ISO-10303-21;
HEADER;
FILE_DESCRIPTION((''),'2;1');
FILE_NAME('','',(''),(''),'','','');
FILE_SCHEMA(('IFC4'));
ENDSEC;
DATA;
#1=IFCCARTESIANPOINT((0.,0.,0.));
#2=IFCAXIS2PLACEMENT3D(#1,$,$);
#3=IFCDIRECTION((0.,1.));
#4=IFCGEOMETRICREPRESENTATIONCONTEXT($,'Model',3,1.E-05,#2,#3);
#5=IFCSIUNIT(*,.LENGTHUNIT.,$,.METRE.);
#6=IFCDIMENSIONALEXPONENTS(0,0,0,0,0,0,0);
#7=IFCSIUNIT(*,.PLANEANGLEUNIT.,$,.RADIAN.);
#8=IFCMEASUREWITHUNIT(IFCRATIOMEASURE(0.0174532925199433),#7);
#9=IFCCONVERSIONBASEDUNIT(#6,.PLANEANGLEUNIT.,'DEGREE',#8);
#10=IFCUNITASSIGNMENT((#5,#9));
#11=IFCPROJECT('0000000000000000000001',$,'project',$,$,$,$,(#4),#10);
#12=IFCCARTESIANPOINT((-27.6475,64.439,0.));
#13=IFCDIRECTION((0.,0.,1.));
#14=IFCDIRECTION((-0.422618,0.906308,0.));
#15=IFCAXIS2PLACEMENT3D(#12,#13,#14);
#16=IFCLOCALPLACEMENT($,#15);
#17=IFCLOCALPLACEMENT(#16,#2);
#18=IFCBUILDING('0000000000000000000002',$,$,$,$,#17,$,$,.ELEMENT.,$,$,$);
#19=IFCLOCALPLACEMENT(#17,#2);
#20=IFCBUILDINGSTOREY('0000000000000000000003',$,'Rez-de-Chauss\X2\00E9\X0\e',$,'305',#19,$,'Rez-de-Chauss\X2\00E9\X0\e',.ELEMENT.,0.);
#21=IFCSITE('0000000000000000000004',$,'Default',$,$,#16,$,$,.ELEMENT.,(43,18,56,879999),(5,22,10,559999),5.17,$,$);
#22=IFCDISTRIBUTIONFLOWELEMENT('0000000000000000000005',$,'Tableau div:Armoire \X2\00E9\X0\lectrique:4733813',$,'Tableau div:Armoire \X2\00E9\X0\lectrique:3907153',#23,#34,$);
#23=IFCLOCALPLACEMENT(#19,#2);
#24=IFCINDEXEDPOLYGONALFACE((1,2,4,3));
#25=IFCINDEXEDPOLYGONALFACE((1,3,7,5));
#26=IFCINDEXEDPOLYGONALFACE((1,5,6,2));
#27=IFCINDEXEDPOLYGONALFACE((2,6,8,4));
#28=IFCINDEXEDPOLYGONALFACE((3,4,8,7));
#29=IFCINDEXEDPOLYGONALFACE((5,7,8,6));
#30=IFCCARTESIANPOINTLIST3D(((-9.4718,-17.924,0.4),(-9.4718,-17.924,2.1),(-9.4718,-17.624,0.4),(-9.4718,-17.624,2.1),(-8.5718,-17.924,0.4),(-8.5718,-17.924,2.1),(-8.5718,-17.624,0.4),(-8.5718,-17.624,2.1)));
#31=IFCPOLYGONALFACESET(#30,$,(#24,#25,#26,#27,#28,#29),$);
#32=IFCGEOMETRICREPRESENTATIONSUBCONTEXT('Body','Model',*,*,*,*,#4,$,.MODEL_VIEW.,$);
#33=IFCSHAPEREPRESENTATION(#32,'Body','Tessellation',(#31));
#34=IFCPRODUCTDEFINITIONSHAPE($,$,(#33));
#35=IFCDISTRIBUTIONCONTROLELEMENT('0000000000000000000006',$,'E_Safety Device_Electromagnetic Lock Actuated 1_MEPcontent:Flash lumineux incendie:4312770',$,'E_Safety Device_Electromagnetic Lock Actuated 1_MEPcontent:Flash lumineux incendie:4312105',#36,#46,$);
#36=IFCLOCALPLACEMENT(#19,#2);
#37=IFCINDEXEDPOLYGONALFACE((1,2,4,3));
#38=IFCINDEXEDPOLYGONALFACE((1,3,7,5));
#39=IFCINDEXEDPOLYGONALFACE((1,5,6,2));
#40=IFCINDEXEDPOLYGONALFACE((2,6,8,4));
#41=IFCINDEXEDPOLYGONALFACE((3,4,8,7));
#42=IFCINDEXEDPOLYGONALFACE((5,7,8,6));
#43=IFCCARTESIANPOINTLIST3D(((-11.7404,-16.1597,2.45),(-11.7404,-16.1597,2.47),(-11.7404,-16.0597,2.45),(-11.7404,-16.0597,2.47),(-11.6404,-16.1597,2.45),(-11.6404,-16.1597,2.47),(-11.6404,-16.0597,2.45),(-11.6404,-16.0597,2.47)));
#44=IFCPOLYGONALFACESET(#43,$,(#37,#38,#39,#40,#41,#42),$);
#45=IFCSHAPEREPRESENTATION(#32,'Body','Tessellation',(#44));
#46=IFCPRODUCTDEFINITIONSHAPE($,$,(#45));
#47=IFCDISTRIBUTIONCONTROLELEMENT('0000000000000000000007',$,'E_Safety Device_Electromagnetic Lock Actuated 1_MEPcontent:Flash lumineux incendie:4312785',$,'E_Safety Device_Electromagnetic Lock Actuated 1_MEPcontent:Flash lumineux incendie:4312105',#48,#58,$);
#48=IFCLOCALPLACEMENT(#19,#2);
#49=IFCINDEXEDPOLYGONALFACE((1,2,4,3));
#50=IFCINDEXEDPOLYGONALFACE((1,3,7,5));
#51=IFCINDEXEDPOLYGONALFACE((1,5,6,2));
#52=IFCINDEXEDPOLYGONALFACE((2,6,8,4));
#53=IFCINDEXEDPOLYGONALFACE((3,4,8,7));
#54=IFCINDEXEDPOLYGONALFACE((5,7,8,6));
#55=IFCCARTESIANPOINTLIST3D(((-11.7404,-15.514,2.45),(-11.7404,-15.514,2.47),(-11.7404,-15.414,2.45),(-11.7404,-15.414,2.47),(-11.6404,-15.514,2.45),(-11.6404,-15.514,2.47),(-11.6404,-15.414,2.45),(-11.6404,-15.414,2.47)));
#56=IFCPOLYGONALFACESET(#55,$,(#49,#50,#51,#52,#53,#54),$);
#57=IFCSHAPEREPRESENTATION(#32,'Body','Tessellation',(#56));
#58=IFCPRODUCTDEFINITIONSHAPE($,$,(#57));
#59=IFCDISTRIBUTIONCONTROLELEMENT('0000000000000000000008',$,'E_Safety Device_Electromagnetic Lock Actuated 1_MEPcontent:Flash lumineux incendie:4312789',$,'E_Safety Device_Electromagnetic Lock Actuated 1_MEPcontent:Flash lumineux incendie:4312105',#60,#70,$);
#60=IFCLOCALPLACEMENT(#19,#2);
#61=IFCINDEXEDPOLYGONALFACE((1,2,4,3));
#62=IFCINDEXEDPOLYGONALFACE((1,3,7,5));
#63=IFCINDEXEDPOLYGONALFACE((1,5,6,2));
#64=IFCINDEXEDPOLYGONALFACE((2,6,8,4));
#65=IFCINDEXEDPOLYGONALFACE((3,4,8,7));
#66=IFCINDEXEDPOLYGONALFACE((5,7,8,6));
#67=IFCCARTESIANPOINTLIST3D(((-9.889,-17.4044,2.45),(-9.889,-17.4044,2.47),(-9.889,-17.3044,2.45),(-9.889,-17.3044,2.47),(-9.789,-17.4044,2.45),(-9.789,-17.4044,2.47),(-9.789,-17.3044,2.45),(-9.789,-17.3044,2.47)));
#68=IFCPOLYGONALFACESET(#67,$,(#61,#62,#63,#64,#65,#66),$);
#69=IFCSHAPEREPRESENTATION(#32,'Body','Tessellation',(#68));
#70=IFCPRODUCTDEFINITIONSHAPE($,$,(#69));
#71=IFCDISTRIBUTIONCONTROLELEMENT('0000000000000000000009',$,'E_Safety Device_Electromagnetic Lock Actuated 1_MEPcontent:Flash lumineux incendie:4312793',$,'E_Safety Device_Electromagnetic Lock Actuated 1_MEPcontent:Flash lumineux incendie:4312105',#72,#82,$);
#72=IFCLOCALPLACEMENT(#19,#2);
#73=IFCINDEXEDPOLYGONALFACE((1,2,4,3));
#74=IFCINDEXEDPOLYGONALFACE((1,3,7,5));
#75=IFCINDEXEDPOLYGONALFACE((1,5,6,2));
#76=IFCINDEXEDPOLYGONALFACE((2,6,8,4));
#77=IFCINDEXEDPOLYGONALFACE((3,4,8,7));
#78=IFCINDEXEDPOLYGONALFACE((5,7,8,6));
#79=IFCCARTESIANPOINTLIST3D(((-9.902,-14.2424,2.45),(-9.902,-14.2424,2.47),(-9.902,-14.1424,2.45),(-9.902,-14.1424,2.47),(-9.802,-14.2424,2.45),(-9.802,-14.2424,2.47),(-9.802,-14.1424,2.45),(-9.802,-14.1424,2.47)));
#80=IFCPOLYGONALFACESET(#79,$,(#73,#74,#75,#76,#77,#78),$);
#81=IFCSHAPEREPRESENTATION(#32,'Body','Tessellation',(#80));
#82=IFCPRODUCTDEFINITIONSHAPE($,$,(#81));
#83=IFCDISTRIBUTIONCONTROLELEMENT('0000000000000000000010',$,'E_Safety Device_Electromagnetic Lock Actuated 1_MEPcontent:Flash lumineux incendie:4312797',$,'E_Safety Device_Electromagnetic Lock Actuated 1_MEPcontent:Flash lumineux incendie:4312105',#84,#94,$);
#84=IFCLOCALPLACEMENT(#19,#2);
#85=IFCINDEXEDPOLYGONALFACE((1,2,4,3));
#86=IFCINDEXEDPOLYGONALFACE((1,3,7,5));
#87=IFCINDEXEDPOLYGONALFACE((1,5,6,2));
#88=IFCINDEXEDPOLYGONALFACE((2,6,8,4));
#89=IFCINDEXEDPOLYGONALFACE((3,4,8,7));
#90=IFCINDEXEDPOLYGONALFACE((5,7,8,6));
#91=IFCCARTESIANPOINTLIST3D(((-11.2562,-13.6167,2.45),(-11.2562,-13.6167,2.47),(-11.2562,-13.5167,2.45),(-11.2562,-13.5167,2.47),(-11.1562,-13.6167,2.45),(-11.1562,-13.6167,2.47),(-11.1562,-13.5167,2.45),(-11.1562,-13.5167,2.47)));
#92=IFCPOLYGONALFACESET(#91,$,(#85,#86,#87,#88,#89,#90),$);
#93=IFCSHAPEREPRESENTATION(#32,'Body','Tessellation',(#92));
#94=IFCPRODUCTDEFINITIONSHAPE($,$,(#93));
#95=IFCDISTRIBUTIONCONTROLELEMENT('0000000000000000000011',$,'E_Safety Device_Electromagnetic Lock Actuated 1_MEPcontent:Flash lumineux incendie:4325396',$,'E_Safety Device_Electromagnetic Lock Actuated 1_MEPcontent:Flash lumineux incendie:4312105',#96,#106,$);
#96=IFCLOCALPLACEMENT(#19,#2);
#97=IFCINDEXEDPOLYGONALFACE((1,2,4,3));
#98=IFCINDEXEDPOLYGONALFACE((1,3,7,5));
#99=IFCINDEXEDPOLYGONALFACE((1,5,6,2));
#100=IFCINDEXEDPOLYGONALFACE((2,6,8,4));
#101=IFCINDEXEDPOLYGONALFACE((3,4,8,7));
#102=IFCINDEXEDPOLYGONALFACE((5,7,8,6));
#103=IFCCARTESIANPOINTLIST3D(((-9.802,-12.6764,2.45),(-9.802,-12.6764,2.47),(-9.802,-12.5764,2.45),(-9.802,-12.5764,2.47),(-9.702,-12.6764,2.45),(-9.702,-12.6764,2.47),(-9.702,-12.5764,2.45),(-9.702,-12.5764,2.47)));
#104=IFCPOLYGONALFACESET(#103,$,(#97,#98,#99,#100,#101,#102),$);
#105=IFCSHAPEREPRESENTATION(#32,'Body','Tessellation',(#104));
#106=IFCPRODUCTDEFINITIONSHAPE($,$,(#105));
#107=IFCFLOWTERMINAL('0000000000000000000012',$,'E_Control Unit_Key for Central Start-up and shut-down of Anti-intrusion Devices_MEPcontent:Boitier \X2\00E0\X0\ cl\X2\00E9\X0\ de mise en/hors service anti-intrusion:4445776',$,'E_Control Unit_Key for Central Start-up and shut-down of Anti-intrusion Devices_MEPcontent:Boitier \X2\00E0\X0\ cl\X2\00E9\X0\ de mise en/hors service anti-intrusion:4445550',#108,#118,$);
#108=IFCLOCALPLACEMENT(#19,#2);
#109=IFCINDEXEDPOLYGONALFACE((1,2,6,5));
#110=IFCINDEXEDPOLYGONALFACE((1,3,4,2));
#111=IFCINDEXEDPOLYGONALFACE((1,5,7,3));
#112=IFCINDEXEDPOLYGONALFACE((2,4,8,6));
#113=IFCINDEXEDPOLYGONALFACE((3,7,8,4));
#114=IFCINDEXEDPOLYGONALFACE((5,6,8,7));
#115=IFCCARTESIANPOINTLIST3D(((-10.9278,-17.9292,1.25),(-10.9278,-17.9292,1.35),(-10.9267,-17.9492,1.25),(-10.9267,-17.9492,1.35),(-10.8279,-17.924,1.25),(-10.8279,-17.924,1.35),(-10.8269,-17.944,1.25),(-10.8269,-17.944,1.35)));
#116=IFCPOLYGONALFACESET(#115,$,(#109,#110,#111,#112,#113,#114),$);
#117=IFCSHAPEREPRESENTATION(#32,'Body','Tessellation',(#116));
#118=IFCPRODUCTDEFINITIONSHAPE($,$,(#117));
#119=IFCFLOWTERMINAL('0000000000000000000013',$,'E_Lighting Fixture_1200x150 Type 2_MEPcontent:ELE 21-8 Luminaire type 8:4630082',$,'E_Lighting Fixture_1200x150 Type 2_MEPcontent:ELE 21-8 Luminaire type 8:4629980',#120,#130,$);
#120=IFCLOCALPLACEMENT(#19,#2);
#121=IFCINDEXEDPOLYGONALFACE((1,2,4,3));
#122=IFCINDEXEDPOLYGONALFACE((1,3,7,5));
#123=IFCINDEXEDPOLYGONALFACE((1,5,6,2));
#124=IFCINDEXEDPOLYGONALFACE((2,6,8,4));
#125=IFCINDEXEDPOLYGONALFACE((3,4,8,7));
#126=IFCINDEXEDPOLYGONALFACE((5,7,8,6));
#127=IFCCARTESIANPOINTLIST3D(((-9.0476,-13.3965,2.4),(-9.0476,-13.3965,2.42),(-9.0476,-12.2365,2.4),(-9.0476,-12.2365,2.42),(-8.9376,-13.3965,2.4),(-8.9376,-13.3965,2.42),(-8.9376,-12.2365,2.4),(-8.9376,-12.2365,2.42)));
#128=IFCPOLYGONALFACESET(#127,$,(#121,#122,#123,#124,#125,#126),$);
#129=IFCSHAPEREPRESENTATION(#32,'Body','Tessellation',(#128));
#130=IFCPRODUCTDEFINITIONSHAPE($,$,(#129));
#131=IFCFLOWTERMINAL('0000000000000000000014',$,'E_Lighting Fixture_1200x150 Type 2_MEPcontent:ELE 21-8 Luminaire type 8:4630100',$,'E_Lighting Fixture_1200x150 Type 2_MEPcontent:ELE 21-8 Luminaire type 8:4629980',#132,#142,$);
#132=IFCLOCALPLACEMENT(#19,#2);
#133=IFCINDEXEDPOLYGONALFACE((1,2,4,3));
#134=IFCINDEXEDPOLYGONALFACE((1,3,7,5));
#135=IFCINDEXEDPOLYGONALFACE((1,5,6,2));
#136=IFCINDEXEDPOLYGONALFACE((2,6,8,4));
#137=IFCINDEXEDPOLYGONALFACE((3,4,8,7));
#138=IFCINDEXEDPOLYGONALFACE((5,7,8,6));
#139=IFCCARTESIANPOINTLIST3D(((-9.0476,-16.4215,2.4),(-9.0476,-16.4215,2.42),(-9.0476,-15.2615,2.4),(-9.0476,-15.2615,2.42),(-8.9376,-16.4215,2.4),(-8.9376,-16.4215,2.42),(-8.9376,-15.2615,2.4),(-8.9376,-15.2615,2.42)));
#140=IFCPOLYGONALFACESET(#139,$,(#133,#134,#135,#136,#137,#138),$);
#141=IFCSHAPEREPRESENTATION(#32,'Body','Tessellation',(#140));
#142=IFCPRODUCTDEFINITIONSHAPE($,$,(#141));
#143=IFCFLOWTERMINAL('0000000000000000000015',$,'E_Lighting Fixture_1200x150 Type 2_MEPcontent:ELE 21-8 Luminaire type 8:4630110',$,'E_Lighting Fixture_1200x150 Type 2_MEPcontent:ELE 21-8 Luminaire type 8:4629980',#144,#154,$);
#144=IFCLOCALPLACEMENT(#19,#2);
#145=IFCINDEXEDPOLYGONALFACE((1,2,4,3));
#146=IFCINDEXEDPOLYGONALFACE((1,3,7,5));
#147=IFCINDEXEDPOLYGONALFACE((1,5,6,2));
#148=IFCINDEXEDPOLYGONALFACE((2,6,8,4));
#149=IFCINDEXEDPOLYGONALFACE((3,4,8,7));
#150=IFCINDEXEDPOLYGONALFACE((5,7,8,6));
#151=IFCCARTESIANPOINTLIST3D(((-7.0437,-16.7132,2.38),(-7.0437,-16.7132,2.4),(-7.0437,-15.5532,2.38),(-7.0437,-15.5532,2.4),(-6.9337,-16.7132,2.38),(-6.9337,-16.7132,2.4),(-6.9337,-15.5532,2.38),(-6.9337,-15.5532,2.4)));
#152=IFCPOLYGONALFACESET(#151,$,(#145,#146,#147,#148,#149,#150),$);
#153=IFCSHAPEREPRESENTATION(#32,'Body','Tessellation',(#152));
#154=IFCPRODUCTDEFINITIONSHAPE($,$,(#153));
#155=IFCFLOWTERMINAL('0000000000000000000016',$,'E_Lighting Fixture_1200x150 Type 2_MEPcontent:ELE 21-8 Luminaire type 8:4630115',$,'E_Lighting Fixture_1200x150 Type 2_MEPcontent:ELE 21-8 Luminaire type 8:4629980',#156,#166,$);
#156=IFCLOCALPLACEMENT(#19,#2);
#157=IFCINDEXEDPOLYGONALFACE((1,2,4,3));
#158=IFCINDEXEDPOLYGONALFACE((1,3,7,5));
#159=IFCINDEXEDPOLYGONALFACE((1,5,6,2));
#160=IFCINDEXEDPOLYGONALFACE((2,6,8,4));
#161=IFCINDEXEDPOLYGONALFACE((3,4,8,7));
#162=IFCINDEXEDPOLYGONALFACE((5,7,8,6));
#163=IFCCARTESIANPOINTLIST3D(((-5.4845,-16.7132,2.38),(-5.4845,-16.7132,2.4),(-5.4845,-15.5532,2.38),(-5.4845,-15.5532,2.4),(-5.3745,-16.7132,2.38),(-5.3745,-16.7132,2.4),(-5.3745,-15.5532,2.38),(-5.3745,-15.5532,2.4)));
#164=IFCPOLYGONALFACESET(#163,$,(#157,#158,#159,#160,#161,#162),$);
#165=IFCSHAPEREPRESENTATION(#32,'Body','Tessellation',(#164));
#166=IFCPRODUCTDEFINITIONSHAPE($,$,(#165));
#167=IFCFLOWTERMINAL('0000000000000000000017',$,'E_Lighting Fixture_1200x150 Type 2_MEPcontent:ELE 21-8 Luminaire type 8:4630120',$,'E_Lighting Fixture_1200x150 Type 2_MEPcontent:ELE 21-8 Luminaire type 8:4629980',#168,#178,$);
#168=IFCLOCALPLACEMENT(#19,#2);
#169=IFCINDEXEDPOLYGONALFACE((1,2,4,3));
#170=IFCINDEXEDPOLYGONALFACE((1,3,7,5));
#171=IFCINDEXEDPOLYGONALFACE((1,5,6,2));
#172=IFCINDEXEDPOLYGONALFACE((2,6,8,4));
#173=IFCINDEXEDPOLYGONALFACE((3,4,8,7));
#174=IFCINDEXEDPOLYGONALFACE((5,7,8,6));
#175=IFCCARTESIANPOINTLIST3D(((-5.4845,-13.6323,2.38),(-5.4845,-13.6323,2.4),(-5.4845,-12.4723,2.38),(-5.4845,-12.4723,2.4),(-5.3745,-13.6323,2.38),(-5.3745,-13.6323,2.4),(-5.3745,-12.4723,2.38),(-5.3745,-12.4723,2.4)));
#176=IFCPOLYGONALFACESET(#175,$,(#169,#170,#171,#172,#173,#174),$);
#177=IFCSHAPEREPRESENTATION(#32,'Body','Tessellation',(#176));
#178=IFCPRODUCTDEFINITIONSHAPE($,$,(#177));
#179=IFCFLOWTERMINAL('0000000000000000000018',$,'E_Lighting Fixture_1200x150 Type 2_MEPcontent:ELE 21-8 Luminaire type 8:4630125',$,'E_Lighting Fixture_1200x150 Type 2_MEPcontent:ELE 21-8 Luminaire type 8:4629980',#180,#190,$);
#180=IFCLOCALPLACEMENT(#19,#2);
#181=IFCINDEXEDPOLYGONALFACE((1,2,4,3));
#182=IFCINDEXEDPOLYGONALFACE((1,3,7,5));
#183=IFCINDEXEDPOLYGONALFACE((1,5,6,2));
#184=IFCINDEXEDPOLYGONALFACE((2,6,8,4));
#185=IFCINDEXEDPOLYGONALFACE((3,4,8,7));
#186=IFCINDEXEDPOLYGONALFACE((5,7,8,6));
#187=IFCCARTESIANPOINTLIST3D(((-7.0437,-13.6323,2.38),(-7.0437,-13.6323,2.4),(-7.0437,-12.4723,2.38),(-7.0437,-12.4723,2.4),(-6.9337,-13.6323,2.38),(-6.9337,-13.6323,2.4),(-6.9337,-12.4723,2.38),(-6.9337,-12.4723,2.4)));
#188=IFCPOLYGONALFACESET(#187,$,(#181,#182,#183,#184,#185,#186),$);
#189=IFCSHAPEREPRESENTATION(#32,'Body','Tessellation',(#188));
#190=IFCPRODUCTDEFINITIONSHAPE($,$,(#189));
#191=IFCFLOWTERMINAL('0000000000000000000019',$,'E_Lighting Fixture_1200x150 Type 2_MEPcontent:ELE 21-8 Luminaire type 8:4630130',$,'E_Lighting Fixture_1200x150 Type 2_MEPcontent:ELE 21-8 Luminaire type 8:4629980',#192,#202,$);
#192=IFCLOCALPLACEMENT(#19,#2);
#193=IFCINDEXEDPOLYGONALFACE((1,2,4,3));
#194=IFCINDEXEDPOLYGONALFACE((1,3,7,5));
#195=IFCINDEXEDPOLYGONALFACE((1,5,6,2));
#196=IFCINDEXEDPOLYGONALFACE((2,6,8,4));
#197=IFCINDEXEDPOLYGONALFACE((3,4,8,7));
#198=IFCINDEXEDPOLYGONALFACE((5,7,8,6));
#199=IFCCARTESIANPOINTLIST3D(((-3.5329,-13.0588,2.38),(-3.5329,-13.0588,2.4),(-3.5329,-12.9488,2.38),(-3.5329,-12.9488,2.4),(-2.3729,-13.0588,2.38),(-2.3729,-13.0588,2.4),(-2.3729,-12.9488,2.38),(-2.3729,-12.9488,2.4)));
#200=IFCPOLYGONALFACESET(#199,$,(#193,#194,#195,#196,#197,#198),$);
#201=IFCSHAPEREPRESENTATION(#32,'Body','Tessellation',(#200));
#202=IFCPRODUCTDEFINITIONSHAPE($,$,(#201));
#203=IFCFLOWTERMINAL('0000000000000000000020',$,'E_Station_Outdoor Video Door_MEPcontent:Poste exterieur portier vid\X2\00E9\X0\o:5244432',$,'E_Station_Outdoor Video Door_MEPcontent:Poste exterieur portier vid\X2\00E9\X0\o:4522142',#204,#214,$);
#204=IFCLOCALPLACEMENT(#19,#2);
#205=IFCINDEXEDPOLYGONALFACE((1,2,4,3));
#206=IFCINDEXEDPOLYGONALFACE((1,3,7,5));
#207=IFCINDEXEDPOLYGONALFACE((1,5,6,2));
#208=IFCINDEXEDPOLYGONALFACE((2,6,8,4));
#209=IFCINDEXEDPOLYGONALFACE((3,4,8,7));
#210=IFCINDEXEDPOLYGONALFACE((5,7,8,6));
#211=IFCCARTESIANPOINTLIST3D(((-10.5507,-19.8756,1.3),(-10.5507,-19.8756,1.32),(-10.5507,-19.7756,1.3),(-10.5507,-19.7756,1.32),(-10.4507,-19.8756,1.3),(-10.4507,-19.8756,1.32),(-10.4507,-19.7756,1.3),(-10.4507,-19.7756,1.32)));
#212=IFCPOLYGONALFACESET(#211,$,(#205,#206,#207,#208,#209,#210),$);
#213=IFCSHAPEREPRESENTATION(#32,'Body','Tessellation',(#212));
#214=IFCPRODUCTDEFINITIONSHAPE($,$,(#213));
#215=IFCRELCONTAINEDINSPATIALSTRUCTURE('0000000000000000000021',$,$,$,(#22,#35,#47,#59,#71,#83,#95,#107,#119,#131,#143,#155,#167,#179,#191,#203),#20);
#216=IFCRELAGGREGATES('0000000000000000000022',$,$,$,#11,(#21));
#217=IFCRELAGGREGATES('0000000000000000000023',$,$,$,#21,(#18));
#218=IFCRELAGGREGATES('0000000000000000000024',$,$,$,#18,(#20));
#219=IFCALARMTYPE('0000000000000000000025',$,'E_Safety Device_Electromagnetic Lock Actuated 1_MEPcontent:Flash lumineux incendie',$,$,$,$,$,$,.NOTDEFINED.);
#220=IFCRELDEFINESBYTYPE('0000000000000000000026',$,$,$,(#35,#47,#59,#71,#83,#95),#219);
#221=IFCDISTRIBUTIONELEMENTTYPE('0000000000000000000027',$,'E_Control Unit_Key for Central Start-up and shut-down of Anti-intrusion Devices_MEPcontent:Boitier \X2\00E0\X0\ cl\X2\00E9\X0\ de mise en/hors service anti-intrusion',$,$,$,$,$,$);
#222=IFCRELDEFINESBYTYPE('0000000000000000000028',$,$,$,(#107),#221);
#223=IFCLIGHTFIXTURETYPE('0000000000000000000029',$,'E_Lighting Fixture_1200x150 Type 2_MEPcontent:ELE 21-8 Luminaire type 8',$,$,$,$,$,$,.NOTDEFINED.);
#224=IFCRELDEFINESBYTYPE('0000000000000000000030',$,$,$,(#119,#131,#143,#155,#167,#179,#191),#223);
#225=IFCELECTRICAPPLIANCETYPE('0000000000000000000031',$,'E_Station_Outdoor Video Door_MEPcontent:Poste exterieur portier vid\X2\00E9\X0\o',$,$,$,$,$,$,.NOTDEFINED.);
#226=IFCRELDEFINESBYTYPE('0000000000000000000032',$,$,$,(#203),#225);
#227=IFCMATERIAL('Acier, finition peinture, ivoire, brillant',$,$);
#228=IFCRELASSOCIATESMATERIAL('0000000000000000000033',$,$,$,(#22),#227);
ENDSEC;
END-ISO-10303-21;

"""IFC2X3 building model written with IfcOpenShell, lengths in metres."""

from ifc_helpers import new_model, entity, si_unit, converted_unit, direction, frame, frame_2d, origin, origin_2d_with_axis, place, context, subcontext, project, spatial, rectangle, extrude, source, transform, mapped, material, type_object, type_shapes, element, save


model = new_model("IFC2X3")

# Units and contexts
model_context = context("Model", 3, precision=1e-05, world=origin(), true_north=direction((0.0, 1.0)))
body_context = subcontext(model_context, "Body", "Model", "MODEL_VIEW")
ifc_project = project(units=[si_unit("LENGTHUNIT", "METRE"), converted_unit("PLANEANGLEUNIT", "DEGREE", entity("IfcRatioMeasure", 0.0174532925199433), si_unit("PLANEANGLEUNIT", "RADIAN"), dimensions=[0, 0, 0, 0, 0, 0, 0])], contexts=[model_context])

# Site, building, storey
site_placement = place(None, frame((-27.6475, 64.439, 0.0), z_axis=(0.0, 0.0, 1.0), x_axis=(-0.422618, 0.906308, 0.0)))
site = spatial("IfcSite", under=ifc_project, at=site_placement, Name="Default", CompositionType="ELEMENT", RefLatitude=(43, 18, 56, 879999), RefLongitude=(5, 22, 10, 559999), RefElevation=5.17)
building_placement = place(site_placement, origin())
building = spatial("IfcBuilding", under=site, at=building_placement, CompositionType="ELEMENT")
storey_placement = place(building_placement, origin())
storey = spatial("IfcBuildingStorey", under=building, at=storey_placement, Name="Rez-de-Chaussée", ObjectType="305", LongName="Rez-de-Chaussée", CompositionType="ELEMENT", Elevation=0.0)

# Distribution flow element
ifc_material_1 = material(Name="Acier, finition peinture, ivoire, brillant")
shared_shape_1 = source(origin(), body_context, "Body", "SweptSolid", [
    extrude(rectangle(XDim=0.9, YDim=0.3, at=origin_2d_with_axis()), frame((0.0, -0.45, 0.0), z_axis=(0.0, 0.0, 1.0), x_axis=(0.0, 1.0, 0.0)), (0.0, 0.0, 1.0), 1.7),
])
distribution_flow_element_placement = place(storey_placement, frame((-8.5718, -17.774, 0.4), z_axis=(0.0, 0.0, 1.0), x_axis=(0.0, -1.0, 0.0)))
element("IfcDistributionFlowElement", 1, at=distribution_flow_element_placement, inside=storey, material=ifc_material_1, Name="Tableau div:Armoire électrique:4733813", ObjectType="Tableau div:Armoire électrique:3907153", context=body_context, shape_type="MappedRepresentation", body=[
    mapped(shared_shape_1, transform((0.0, 0.0, 0.0), scale=1.0)),
])

# Distribution control elements
alarm_type_1 = type_object("IfcAlarmType", Name="E_Safety Device_Electromagnetic Lock Actuated 1_MEPcontent:Flash lumineux incendie", PredefinedType="NOTDEFINED")
shared_shape_2 = source(origin(), body_context, "Body", "SweptSolid", [
    extrude(rectangle(XDim=0.1, YDim=0.1, at=origin_2d_with_axis()), frame((0.0, 0.0, 0.0), z_axis=(0.0, 0.0, 1.0), x_axis=(0.0, -1.0, 0.0)), (0.0, 0.0, 1.0), 0.02),
])
type_shapes(alarm_type_1, [shared_shape_2])
for number, where, z_axis, x_axis, name in (
    (2, (-11.6904, -16.1097, 2.45), (0.0, 0.0, 1.0), (0.0, -1.0, 0.0), "E_Safety Device_Electromagnetic Lock Actuated 1_MEPcontent:Flash lumineux incendie:4312770"),
    (3, (-11.6904, -15.464, 2.45), (0.0, 0.0, 1.0), (0.0, -1.0, 0.0), "E_Safety Device_Electromagnetic Lock Actuated 1_MEPcontent:Flash lumineux incendie:4312785"),
    (4, (-9.839, -17.3544, 2.45), (0.0, 0.0, 1.0), (0.0, -1.0, 0.0), "E_Safety Device_Electromagnetic Lock Actuated 1_MEPcontent:Flash lumineux incendie:4312789"),
    (5, (-9.852, -14.1924, 2.45), (0.0, 0.0, 1.0), (0.0, -1.0, 0.0), "E_Safety Device_Electromagnetic Lock Actuated 1_MEPcontent:Flash lumineux incendie:4312793"),
    (6, (-11.2062, -13.5667, 2.45), (0.0, 0.0, 1.0), (0.0, -1.0, 0.0), "E_Safety Device_Electromagnetic Lock Actuated 1_MEPcontent:Flash lumineux incendie:4312797"),
    (7, (-9.752, -12.6264, 2.45), (0.0, 0.0, 1.0), (0.0, -1.0, 0.0), "E_Safety Device_Electromagnetic Lock Actuated 1_MEPcontent:Flash lumineux incendie:4325396"),
):
    element("IfcDistributionControlElement", number, at=place(storey_placement, frame(where, z_axis=z_axis, x_axis=x_axis)), inside=storey, type_object=alarm_type_1, Name=name, ObjectType="E_Safety Device_Electromagnetic Lock Actuated 1_MEPcontent:Flash lumineux incendie:4312105", context=body_context, shape_type="MappedRepresentation", body=[
        mapped(shared_shape_2, transform((0.0, 0.0, 0.0), scale=1.0)),
    ])

# Flow terminals
distribution_element_type_1 = type_object("IfcDistributionElementType", Name="E_Control Unit_Key for Central Start-up and shut-down of Anti-intrusion Devices_MEPcontent:Boitier à clé de mise en/hors service anti-intrusion")
shared_shape_3 = source(origin(), body_context, "Body", "SweptSolid", [
    extrude(rectangle(XDim=0.02, YDim=0.1, at=frame_2d((0.0, 0.0), x_axis=(1.0, 0.0))), frame((0.0, -0.01, -0.05), z_axis=(0.0, 0.0, 1.0), x_axis=(0.0, 1.0, 0.0)), (0.0, 0.0, 1.0), 0.1),
])
type_shapes(distribution_element_type_1, [shared_shape_3])
flow_terminal_1_placement = place(storey_placement, frame((-10.8779, -17.9266, 1.3), z_axis=(0.0, 0.0, 1.0), x_axis=(0.998641, 0.05212, 0.0)))
element("IfcFlowTerminal", 8, at=flow_terminal_1_placement, inside=storey, type_object=distribution_element_type_1, Name="E_Control Unit_Key for Central Start-up and shut-down of Anti-intrusion Devices_MEPcontent:Boitier à clé de mise en/hors service anti-intrusion:4445776", ObjectType="E_Control Unit_Key for Central Start-up and shut-down of Anti-intrusion Devices_MEPcontent:Boitier à clé de mise en/hors service anti-intrusion:4445550", context=body_context, shape_type="MappedRepresentation", body=[
    mapped(shared_shape_3, transform((0.0, 0.0, 0.0), scale=1.0)),
])
light_fixture_type_1 = type_object("IfcLightFixtureType", Name="E_Lighting Fixture_1200x150 Type 2_MEPcontent:ELE 21-8 Luminaire type 8", PredefinedType="NOTDEFINED")
shared_shape_4 = source(origin(), body_context, "Body", "SweptSolid", [
    extrude(rectangle(XDim=0.11, YDim=1.16, at=origin_2d_with_axis()), frame((0.0, 0.0, 0.0), z_axis=(0.0, 0.0, 1.0), x_axis=(0.0, -1.0, 0.0)), (0.0, 0.0, 1.0), 0.02),
])
type_shapes(light_fixture_type_1, [shared_shape_4])
for number, where, z_axis, x_axis, name in (
    (9, (-8.9926, -12.8165, 2.4), (0.0, 0.0, 1.0), (0.0, -1.0, 0.0), "E_Lighting Fixture_1200x150 Type 2_MEPcontent:ELE 21-8 Luminaire type 8:4630082"),
    (10, (-8.9926, -15.8415, 2.4), (0.0, 0.0, 1.0), (0.0, -1.0, 0.0), "E_Lighting Fixture_1200x150 Type 2_MEPcontent:ELE 21-8 Luminaire type 8:4630100"),
    (11, (-6.9887, -16.1332, 2.38), (0.0, 0.0, 1.0), (0.0, -1.0, 0.0), "E_Lighting Fixture_1200x150 Type 2_MEPcontent:ELE 21-8 Luminaire type 8:4630110"),
    (12, (-5.4295, -16.1332, 2.38), (0.0, 0.0, 1.0), (0.0, -1.0, 0.0), "E_Lighting Fixture_1200x150 Type 2_MEPcontent:ELE 21-8 Luminaire type 8:4630115"),
    (13, (-5.4295, -13.0523, 2.38), (0.0, 0.0, 1.0), (0.0, -1.0, 0.0), "E_Lighting Fixture_1200x150 Type 2_MEPcontent:ELE 21-8 Luminaire type 8:4630120"),
    (14, (-6.9887, -13.0523, 2.38), (0.0, 0.0, 1.0), (0.0, -1.0, 0.0), "E_Lighting Fixture_1200x150 Type 2_MEPcontent:ELE 21-8 Luminaire type 8:4630125"),
):
    element("IfcFlowTerminal", number, at=place(storey_placement, frame(where, z_axis=z_axis, x_axis=x_axis)), inside=storey, type_object=light_fixture_type_1, Name=name, ObjectType="E_Lighting Fixture_1200x150 Type 2_MEPcontent:ELE 21-8 Luminaire type 8:4629980", context=body_context, shape_type="MappedRepresentation", body=[
        mapped(shared_shape_4, transform((0.0, 0.0, 0.0), scale=1.0)),
    ])
flow_terminal_2_placement = place(storey_placement, frame((-2.9529, -13.0038, 2.38)))
element("IfcFlowTerminal", 15, at=flow_terminal_2_placement, inside=storey, type_object=light_fixture_type_1, Name="E_Lighting Fixture_1200x150 Type 2_MEPcontent:ELE 21-8 Luminaire type 8:4630130", ObjectType="E_Lighting Fixture_1200x150 Type 2_MEPcontent:ELE 21-8 Luminaire type 8:4629980", context=body_context, shape_type="MappedRepresentation", body=[
    mapped(shared_shape_4, transform((0.0, 0.0, 0.0), scale=1.0)),
])
electric_appliance_type_1 = type_object("IfcElectricApplianceType", Name="E_Station_Outdoor Video Door_MEPcontent:Poste exterieur portier vidéo", PredefinedType="NOTDEFINED")
shared_shape_5 = source(origin(), body_context, "Body", "SweptSolid", [
    extrude(rectangle(XDim=0.1, YDim=0.1, at=origin_2d_with_axis()), frame((0.0, 0.0, 0.0), z_axis=(0.0, 0.0, 1.0), x_axis=(0.0, -1.0, 0.0)), (0.0, 0.0, 1.0), 0.02),
])
type_shapes(electric_appliance_type_1, [shared_shape_5])
flow_terminal_3_placement = place(storey_placement, frame((-10.5007, -19.8256, 1.3), z_axis=(0.0, 0.0, 1.0), x_axis=(-1.0, 0.0, 0.0)))
element("IfcFlowTerminal", 16, at=flow_terminal_3_placement, inside=storey, type_object=electric_appliance_type_1, Name="E_Station_Outdoor Video Door_MEPcontent:Poste exterieur portier vidéo:5244432", ObjectType="E_Station_Outdoor Video Door_MEPcontent:Poste exterieur portier vidéo:4522142", context=body_context, shape_type="MappedRepresentation", body=[
    mapped(shared_shape_5, transform((0.0, 0.0, 0.0), scale=1.0)),
])

save(model, "model.ifc")
